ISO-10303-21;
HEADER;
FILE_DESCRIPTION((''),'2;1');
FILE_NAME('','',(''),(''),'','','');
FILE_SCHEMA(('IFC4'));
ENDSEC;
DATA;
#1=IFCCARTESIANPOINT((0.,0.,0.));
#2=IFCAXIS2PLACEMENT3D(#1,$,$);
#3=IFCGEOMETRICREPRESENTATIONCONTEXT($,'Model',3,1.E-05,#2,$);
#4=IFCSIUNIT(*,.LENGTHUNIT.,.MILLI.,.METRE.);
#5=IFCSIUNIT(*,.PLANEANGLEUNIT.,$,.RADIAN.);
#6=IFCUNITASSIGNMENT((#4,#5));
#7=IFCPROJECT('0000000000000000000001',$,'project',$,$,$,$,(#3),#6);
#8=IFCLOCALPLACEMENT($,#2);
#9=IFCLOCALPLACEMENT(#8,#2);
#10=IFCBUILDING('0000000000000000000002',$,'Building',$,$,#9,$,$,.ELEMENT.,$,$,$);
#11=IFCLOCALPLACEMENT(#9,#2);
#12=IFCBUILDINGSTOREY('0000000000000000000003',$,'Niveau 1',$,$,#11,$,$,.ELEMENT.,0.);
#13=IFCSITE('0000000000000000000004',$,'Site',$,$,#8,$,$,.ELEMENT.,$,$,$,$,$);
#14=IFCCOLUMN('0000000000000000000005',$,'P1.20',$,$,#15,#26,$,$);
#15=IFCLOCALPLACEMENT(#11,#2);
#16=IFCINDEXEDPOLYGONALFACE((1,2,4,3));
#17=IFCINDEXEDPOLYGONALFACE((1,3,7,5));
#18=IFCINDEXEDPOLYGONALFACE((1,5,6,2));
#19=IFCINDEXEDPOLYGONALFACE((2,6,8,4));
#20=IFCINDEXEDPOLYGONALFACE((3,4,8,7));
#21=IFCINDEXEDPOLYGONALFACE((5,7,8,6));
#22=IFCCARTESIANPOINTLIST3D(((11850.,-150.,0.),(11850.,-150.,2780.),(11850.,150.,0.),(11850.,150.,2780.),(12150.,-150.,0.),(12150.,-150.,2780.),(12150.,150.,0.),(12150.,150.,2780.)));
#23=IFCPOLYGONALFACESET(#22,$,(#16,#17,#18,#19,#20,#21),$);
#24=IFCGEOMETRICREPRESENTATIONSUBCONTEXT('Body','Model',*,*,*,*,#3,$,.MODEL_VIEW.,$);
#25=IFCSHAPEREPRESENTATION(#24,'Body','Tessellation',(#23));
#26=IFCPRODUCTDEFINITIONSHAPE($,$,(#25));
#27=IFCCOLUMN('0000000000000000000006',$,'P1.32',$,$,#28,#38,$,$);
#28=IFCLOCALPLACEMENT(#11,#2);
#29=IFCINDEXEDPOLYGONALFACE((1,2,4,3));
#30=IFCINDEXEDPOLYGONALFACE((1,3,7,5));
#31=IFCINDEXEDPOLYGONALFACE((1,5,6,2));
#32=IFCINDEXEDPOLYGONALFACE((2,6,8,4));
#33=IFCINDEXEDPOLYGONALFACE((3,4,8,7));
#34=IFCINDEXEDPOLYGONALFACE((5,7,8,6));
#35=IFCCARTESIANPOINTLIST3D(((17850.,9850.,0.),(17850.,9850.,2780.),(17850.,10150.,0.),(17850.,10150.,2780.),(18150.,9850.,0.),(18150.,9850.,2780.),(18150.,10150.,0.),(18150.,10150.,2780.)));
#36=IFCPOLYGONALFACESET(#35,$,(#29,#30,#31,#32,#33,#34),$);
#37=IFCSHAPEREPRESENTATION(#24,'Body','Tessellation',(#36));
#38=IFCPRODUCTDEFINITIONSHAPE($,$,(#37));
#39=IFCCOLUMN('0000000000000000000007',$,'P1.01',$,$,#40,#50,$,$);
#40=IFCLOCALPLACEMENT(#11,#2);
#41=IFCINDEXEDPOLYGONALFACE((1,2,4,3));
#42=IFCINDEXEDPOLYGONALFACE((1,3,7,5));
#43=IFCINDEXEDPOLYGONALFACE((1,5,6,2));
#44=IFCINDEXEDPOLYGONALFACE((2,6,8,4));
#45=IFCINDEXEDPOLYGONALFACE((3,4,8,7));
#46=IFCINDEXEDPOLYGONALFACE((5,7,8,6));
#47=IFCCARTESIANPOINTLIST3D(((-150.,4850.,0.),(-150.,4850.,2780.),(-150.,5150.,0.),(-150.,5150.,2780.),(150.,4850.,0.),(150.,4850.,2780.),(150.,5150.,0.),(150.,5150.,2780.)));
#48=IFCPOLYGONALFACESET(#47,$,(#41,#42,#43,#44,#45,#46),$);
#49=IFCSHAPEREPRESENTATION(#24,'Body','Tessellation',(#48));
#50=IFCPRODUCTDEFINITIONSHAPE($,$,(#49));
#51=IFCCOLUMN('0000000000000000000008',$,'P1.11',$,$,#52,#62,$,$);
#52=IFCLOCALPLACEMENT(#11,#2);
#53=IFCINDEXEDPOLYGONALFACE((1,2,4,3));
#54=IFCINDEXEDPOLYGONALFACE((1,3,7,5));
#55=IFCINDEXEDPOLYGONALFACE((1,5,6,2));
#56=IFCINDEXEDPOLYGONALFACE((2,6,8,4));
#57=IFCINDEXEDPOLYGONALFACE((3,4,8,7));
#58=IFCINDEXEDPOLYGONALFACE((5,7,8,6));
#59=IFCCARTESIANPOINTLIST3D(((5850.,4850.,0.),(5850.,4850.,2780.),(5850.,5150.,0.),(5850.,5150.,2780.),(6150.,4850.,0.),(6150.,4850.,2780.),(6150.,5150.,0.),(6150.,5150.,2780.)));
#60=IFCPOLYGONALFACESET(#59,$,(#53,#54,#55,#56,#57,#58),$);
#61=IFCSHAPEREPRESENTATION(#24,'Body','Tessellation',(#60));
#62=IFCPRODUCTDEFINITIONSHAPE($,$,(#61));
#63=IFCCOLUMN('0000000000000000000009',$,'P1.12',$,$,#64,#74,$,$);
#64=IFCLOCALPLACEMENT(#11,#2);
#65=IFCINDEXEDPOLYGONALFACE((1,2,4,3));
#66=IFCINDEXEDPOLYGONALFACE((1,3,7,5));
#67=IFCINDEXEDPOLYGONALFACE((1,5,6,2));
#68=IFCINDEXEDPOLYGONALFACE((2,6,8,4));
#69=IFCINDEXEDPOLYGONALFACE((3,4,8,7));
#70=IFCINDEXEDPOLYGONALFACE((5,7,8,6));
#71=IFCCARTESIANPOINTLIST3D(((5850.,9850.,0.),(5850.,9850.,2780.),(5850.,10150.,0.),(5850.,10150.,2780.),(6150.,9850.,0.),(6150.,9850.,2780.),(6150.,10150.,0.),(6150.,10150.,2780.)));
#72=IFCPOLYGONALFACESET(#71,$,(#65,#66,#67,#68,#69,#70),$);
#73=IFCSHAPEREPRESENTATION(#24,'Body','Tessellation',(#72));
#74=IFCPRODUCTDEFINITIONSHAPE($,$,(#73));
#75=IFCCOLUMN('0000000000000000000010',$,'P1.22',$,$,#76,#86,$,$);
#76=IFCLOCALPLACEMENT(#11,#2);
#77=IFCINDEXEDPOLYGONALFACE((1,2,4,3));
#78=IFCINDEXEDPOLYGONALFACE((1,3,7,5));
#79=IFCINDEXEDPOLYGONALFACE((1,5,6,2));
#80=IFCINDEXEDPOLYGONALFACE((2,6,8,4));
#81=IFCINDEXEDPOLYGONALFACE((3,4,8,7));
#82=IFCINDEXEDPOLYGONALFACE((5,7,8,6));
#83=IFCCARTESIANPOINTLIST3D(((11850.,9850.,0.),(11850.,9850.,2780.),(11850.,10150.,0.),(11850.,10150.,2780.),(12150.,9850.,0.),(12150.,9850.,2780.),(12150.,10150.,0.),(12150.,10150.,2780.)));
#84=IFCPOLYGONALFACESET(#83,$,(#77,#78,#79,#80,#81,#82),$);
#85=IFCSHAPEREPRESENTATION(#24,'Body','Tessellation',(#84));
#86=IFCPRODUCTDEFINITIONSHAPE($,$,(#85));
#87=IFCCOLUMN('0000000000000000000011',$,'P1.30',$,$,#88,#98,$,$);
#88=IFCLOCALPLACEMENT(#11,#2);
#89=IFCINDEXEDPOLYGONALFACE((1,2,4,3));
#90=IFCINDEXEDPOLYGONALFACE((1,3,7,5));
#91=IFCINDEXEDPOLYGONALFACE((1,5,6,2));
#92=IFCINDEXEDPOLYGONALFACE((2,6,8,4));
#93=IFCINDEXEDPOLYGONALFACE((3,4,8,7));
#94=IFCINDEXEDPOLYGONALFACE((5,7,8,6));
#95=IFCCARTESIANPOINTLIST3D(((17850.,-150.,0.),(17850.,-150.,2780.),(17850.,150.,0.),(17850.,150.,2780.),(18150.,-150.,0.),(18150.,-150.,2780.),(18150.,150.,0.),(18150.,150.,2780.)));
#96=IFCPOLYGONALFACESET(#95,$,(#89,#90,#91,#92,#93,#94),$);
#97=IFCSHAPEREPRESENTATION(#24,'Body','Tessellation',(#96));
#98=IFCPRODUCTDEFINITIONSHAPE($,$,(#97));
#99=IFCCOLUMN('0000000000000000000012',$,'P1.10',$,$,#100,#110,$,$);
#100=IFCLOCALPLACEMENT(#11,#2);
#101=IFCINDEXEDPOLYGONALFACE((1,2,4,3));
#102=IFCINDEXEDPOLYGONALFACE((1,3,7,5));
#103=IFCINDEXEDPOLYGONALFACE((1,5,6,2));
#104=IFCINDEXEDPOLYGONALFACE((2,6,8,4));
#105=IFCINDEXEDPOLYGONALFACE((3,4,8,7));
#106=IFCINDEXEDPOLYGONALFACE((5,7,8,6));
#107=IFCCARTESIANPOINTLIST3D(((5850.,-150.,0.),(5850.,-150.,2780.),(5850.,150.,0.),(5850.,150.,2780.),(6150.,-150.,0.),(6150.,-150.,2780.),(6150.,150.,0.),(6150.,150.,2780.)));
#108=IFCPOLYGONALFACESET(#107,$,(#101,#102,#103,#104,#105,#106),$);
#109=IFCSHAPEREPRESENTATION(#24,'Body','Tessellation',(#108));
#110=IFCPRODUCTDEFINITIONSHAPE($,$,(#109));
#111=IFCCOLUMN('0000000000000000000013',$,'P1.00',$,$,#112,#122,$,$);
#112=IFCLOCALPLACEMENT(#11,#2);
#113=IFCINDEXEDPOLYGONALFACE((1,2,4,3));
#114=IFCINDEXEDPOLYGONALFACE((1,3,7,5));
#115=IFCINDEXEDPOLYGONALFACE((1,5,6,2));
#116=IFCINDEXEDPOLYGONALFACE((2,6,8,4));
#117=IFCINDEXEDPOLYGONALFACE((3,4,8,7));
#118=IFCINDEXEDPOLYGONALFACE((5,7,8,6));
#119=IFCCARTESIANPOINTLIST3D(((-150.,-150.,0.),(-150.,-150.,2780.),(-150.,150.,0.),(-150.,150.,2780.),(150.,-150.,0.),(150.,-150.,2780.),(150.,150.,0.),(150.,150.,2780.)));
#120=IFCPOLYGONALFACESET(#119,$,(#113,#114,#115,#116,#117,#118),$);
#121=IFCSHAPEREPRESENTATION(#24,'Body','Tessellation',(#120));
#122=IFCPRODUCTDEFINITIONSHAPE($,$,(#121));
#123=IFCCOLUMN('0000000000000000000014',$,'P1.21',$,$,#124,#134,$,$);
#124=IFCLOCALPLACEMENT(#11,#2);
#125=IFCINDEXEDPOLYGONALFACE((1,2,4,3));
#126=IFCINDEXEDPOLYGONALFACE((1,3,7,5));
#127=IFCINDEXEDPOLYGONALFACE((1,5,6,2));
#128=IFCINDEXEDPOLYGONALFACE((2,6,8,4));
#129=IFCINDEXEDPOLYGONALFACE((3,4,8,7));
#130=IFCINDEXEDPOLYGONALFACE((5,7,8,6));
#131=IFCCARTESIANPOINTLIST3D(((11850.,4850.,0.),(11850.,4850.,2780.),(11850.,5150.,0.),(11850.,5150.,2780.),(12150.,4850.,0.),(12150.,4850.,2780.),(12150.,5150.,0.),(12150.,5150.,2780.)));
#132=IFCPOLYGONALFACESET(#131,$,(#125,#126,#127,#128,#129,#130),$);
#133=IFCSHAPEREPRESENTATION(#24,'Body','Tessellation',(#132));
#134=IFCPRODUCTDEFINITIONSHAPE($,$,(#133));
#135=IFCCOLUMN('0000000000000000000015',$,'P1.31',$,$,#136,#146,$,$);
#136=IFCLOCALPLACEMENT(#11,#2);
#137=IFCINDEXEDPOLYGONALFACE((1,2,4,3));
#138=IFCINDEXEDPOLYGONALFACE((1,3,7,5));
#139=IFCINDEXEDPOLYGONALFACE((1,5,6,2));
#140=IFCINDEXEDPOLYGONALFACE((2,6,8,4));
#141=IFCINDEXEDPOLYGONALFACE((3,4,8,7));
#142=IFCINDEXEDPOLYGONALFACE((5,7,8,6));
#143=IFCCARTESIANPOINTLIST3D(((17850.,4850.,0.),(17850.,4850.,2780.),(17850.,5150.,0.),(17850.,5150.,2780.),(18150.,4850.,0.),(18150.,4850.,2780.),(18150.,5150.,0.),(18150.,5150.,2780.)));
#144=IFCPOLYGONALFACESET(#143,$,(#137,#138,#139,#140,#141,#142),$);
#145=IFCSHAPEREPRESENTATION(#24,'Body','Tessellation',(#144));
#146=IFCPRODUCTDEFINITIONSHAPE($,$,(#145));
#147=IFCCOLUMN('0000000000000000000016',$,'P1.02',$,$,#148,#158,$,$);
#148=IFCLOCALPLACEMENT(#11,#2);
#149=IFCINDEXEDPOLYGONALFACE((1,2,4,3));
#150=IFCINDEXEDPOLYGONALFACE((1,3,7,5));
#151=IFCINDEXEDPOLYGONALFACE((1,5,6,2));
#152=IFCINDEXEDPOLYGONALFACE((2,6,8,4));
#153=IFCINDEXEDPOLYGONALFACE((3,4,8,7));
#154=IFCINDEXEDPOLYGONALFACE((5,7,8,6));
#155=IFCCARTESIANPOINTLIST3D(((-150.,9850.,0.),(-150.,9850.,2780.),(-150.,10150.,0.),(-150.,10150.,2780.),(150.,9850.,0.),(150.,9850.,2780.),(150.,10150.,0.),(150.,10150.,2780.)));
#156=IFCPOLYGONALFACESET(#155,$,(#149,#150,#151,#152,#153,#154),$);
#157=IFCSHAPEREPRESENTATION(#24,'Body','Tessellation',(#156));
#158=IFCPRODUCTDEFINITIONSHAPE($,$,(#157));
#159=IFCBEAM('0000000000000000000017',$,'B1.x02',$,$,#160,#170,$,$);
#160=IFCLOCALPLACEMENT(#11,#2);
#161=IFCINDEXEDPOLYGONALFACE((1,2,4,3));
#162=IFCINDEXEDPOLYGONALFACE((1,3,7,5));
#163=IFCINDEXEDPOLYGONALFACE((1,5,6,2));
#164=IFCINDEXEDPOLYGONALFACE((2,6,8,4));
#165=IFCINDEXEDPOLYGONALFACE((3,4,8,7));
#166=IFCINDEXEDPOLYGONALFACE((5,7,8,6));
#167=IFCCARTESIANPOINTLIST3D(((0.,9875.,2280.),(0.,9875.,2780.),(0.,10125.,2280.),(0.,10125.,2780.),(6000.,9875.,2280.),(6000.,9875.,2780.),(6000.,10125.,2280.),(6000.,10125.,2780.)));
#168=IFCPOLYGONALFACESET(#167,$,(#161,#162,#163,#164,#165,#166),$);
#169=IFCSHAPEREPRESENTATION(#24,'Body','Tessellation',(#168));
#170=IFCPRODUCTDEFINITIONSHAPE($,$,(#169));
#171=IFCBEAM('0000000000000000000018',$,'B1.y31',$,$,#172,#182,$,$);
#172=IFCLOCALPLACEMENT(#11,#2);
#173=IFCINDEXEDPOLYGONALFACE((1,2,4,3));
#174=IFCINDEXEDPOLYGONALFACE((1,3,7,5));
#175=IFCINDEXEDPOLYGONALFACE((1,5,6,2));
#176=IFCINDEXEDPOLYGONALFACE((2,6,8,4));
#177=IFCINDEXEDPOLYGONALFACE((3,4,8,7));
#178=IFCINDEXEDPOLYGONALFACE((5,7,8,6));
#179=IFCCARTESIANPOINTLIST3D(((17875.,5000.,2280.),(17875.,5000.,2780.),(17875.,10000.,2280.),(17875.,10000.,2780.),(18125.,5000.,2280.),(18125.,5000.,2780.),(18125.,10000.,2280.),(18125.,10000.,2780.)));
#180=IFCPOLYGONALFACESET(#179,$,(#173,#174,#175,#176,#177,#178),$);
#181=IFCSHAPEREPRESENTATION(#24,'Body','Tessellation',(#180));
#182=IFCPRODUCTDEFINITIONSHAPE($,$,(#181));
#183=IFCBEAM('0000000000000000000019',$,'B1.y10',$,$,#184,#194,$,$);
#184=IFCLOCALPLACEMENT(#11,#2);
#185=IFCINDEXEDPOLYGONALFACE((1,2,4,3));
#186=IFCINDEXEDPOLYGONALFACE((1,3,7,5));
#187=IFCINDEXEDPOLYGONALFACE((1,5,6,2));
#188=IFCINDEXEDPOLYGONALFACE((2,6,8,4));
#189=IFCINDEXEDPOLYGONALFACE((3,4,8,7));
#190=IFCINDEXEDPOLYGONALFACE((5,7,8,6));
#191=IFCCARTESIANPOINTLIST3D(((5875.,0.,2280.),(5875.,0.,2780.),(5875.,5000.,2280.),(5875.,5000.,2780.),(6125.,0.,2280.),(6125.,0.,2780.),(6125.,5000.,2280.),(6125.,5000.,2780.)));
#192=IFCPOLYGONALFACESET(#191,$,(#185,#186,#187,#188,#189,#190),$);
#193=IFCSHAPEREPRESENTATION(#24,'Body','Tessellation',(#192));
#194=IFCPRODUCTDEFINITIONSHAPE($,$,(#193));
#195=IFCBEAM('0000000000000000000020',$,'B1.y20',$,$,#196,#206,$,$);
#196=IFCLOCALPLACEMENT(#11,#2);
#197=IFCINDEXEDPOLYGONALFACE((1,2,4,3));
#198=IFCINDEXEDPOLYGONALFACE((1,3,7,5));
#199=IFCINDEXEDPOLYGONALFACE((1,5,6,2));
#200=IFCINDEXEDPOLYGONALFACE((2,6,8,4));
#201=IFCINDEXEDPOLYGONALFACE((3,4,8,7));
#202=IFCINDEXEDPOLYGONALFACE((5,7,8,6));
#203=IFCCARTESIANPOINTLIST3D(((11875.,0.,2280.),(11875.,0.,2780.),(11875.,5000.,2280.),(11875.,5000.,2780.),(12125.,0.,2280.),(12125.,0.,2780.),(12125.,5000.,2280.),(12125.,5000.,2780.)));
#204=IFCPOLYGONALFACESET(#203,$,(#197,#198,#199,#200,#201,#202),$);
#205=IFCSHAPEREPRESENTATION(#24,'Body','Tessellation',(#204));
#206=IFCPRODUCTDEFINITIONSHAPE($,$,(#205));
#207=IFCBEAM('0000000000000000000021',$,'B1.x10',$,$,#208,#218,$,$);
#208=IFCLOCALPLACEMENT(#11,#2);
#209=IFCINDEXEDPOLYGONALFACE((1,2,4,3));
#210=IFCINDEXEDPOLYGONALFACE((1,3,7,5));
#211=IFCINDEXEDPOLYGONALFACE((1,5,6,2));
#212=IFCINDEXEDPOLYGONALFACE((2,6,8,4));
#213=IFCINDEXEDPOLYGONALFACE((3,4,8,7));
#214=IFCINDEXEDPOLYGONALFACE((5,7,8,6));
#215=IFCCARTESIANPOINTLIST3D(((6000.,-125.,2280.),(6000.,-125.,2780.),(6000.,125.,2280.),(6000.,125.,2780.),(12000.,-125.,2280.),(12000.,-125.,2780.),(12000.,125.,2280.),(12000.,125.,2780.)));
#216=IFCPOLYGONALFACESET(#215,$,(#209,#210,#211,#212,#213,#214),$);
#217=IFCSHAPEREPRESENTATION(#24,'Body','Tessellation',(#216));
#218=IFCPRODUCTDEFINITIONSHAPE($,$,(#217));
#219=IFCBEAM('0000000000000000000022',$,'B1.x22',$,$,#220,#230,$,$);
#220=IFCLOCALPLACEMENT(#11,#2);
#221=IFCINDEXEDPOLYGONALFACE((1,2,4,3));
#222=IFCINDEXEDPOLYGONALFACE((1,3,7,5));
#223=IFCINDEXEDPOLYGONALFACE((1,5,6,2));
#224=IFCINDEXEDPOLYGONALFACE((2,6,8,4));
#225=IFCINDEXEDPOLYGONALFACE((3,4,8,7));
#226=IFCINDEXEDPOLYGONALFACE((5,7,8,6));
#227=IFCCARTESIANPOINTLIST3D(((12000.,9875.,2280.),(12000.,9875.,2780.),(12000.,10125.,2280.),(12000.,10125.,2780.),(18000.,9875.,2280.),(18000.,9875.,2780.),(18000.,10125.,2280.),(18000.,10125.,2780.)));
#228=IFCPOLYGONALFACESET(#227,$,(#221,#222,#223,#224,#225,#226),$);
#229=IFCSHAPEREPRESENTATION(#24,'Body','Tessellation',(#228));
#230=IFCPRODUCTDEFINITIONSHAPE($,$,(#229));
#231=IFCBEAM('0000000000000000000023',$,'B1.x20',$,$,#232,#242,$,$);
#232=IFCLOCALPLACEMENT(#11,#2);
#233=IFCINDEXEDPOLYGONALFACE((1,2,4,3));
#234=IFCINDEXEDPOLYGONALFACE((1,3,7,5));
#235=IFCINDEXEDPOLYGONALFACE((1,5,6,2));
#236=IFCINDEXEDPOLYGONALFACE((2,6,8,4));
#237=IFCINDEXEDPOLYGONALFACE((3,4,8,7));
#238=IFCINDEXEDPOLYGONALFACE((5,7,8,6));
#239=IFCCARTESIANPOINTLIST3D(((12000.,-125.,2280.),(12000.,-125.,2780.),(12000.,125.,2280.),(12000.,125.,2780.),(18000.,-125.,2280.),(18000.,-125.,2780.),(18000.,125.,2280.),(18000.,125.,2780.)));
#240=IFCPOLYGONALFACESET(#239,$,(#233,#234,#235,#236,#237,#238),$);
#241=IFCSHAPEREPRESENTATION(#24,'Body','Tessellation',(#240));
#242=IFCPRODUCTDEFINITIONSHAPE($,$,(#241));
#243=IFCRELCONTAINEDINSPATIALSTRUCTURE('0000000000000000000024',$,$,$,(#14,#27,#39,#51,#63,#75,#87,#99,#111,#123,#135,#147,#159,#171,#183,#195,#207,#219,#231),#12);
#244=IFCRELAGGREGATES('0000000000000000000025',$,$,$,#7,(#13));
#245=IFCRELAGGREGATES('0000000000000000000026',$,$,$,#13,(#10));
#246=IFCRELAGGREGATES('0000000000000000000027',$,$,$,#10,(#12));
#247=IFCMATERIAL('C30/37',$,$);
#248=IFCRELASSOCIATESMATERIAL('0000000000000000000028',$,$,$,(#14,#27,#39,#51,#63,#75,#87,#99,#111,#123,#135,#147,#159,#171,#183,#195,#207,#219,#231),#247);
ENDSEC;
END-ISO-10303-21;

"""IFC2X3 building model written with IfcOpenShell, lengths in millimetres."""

from ifc_helpers import new_model, si_unit, frame, origin, origin_2d, place, context, subcontext, project, spatial, rectangle, extrude, material, element, save


model = new_model("IFC2X3")

# Units and contexts
model_context = context("Model", 3, precision=1e-05, world=origin())
body_context = subcontext(model_context, "Body", "Model", "MODEL_VIEW")
ifc_project = project(units=[si_unit("LENGTHUNIT", "METRE", prefix="MILLI"), si_unit("PLANEANGLEUNIT", "RADIAN")], contexts=[model_context])

# Site, building, storey
site_placement = place(None, origin())
site = spatial("IfcSite", under=ifc_project, at=site_placement, Name="Site", CompositionType="ELEMENT")
building_placement = place(site_placement, origin())
building = spatial("IfcBuilding", under=site, at=building_placement, Name="Building", CompositionType="ELEMENT")
storey_placement = place(building_placement, origin())
storey = spatial("IfcBuildingStorey", under=building, at=storey_placement, Name="Niveau 1", CompositionType="ELEMENT", Elevation=0.0)

# Columns
ifc_material = material(Name="C30/37")
for number, where, z_axis, x_axis, name in (
    (1, (12000.0, 0.0, 0.0), (0.0, 0.0, 1.0), (1.0, 0.0, 0.0), "P1.20"),
    (2, (18000.0, 10000.0, 0.0), (0.0, 0.0, 1.0), (1.0, 0.0, 0.0), "P1.32"),
    (3, (0.0, 5000.0, 0.0), (0.0, 0.0, 1.0), (1.0, 0.0, 0.0), "P1.01"),
    (4, (6000.0, 5000.0, 0.0), (0.0, 0.0, 1.0), (1.0, 0.0, 0.0), "P1.11"),
    (5, (6000.0, 10000.0, 0.0), (0.0, 0.0, 1.0), (1.0, 0.0, 0.0), "P1.12"),
    (6, (12000.0, 10000.0, 0.0), (0.0, 0.0, 1.0), (1.0, 0.0, 0.0), "P1.22"),
    (7, (18000.0, 0.0, 0.0), (0.0, 0.0, 1.0), (1.0, 0.0, 0.0), "P1.30"),
    (8, (6000.0, 0.0, 0.0), (0.0, 0.0, 1.0), (1.0, 0.0, 0.0), "P1.10"),
    (9, (0.0, 0.0, 0.0), (0.0, 0.0, 1.0), (1.0, 0.0, 0.0), "P1.00"),
    (10, (12000.0, 5000.0, 0.0), (0.0, 0.0, 1.0), (1.0, 0.0, 0.0), "P1.21"),
    (11, (18000.0, 5000.0, 0.0), (0.0, 0.0, 1.0), (1.0, 0.0, 0.0), "P1.31"),
    (12, (0.0, 10000.0, 0.0), (0.0, 0.0, 1.0), (1.0, 0.0, 0.0), "P1.02"),
):
    element("IfcColumn", number, at=place(storey_placement, frame(where, z_axis=z_axis, x_axis=x_axis)), inside=storey, material=ifc_material, Name=name, context=body_context, shape_type="SweptSolid", body=[
        extrude(rectangle(XDim=300.0, YDim=300.0, at=origin_2d()), origin(), (0.0, 0.0, 1.0), 2780.0),
    ])

# Beams
beam_1_placement = place(storey_placement, frame((0.0, 10000.0, 2530.0), z_axis=(1.0, 0.0, 0.0), x_axis=(0.0, 1.0, 0.0)))
element("IfcBeam", 13, at=beam_1_placement, inside=storey, material=ifc_material, Name="B1.x02", context=body_context, shape_type="SweptSolid", body=[
    extrude(rectangle(XDim=250.0, YDim=500.0, at=origin_2d()), origin(), (0.0, 0.0, 1.0), 6000.0),
])
for number, where, z_axis, x_axis, name in (
    (14, (18000.0, 5000.0, 2530.0), (0.0, 1.0, 0.0), (-1.0, 0.0, 0.0), "B1.y31"),
    (15, (6000.0, 0.0, 2530.0), (0.0, 1.0, 0.0), (-1.0, 0.0, 0.0), "B1.y10"),
    (16, (12000.0, 0.0, 2530.0), (0.0, 1.0, 0.0), (-1.0, 0.0, 0.0), "B1.y20"),
):
    element("IfcBeam", number, at=place(storey_placement, frame(where, z_axis=z_axis, x_axis=x_axis)), inside=storey, material=ifc_material, Name=name, context=body_context, shape_type="SweptSolid", body=[
        extrude(rectangle(XDim=250.0, YDim=500.0, at=origin_2d()), origin(), (0.0, 0.0, 1.0), 5000.0),
    ])
for number, where, z_axis, x_axis, name in (
    (17, (6000.0, 0.0, 2530.0), (1.0, 0.0, 0.0), (0.0, 1.0, 0.0), "B1.x10"),
    (18, (12000.0, 10000.0, 2530.0), (1.0, 0.0, 0.0), (0.0, 1.0, 0.0), "B1.x22"),
    (19, (12000.0, 0.0, 2530.0), (1.0, 0.0, 0.0), (0.0, 1.0, 0.0), "B1.x20"),
):
    element("IfcBeam", number, at=place(storey_placement, frame(where, z_axis=z_axis, x_axis=x_axis)), inside=storey, material=ifc_material, Name=name, context=body_context, shape_type="SweptSolid", body=[
        extrude(rectangle(XDim=250.0, YDim=500.0, at=origin_2d()), origin(), (0.0, 0.0, 1.0), 6000.0),
    ])

save(model, "model.ifc")
